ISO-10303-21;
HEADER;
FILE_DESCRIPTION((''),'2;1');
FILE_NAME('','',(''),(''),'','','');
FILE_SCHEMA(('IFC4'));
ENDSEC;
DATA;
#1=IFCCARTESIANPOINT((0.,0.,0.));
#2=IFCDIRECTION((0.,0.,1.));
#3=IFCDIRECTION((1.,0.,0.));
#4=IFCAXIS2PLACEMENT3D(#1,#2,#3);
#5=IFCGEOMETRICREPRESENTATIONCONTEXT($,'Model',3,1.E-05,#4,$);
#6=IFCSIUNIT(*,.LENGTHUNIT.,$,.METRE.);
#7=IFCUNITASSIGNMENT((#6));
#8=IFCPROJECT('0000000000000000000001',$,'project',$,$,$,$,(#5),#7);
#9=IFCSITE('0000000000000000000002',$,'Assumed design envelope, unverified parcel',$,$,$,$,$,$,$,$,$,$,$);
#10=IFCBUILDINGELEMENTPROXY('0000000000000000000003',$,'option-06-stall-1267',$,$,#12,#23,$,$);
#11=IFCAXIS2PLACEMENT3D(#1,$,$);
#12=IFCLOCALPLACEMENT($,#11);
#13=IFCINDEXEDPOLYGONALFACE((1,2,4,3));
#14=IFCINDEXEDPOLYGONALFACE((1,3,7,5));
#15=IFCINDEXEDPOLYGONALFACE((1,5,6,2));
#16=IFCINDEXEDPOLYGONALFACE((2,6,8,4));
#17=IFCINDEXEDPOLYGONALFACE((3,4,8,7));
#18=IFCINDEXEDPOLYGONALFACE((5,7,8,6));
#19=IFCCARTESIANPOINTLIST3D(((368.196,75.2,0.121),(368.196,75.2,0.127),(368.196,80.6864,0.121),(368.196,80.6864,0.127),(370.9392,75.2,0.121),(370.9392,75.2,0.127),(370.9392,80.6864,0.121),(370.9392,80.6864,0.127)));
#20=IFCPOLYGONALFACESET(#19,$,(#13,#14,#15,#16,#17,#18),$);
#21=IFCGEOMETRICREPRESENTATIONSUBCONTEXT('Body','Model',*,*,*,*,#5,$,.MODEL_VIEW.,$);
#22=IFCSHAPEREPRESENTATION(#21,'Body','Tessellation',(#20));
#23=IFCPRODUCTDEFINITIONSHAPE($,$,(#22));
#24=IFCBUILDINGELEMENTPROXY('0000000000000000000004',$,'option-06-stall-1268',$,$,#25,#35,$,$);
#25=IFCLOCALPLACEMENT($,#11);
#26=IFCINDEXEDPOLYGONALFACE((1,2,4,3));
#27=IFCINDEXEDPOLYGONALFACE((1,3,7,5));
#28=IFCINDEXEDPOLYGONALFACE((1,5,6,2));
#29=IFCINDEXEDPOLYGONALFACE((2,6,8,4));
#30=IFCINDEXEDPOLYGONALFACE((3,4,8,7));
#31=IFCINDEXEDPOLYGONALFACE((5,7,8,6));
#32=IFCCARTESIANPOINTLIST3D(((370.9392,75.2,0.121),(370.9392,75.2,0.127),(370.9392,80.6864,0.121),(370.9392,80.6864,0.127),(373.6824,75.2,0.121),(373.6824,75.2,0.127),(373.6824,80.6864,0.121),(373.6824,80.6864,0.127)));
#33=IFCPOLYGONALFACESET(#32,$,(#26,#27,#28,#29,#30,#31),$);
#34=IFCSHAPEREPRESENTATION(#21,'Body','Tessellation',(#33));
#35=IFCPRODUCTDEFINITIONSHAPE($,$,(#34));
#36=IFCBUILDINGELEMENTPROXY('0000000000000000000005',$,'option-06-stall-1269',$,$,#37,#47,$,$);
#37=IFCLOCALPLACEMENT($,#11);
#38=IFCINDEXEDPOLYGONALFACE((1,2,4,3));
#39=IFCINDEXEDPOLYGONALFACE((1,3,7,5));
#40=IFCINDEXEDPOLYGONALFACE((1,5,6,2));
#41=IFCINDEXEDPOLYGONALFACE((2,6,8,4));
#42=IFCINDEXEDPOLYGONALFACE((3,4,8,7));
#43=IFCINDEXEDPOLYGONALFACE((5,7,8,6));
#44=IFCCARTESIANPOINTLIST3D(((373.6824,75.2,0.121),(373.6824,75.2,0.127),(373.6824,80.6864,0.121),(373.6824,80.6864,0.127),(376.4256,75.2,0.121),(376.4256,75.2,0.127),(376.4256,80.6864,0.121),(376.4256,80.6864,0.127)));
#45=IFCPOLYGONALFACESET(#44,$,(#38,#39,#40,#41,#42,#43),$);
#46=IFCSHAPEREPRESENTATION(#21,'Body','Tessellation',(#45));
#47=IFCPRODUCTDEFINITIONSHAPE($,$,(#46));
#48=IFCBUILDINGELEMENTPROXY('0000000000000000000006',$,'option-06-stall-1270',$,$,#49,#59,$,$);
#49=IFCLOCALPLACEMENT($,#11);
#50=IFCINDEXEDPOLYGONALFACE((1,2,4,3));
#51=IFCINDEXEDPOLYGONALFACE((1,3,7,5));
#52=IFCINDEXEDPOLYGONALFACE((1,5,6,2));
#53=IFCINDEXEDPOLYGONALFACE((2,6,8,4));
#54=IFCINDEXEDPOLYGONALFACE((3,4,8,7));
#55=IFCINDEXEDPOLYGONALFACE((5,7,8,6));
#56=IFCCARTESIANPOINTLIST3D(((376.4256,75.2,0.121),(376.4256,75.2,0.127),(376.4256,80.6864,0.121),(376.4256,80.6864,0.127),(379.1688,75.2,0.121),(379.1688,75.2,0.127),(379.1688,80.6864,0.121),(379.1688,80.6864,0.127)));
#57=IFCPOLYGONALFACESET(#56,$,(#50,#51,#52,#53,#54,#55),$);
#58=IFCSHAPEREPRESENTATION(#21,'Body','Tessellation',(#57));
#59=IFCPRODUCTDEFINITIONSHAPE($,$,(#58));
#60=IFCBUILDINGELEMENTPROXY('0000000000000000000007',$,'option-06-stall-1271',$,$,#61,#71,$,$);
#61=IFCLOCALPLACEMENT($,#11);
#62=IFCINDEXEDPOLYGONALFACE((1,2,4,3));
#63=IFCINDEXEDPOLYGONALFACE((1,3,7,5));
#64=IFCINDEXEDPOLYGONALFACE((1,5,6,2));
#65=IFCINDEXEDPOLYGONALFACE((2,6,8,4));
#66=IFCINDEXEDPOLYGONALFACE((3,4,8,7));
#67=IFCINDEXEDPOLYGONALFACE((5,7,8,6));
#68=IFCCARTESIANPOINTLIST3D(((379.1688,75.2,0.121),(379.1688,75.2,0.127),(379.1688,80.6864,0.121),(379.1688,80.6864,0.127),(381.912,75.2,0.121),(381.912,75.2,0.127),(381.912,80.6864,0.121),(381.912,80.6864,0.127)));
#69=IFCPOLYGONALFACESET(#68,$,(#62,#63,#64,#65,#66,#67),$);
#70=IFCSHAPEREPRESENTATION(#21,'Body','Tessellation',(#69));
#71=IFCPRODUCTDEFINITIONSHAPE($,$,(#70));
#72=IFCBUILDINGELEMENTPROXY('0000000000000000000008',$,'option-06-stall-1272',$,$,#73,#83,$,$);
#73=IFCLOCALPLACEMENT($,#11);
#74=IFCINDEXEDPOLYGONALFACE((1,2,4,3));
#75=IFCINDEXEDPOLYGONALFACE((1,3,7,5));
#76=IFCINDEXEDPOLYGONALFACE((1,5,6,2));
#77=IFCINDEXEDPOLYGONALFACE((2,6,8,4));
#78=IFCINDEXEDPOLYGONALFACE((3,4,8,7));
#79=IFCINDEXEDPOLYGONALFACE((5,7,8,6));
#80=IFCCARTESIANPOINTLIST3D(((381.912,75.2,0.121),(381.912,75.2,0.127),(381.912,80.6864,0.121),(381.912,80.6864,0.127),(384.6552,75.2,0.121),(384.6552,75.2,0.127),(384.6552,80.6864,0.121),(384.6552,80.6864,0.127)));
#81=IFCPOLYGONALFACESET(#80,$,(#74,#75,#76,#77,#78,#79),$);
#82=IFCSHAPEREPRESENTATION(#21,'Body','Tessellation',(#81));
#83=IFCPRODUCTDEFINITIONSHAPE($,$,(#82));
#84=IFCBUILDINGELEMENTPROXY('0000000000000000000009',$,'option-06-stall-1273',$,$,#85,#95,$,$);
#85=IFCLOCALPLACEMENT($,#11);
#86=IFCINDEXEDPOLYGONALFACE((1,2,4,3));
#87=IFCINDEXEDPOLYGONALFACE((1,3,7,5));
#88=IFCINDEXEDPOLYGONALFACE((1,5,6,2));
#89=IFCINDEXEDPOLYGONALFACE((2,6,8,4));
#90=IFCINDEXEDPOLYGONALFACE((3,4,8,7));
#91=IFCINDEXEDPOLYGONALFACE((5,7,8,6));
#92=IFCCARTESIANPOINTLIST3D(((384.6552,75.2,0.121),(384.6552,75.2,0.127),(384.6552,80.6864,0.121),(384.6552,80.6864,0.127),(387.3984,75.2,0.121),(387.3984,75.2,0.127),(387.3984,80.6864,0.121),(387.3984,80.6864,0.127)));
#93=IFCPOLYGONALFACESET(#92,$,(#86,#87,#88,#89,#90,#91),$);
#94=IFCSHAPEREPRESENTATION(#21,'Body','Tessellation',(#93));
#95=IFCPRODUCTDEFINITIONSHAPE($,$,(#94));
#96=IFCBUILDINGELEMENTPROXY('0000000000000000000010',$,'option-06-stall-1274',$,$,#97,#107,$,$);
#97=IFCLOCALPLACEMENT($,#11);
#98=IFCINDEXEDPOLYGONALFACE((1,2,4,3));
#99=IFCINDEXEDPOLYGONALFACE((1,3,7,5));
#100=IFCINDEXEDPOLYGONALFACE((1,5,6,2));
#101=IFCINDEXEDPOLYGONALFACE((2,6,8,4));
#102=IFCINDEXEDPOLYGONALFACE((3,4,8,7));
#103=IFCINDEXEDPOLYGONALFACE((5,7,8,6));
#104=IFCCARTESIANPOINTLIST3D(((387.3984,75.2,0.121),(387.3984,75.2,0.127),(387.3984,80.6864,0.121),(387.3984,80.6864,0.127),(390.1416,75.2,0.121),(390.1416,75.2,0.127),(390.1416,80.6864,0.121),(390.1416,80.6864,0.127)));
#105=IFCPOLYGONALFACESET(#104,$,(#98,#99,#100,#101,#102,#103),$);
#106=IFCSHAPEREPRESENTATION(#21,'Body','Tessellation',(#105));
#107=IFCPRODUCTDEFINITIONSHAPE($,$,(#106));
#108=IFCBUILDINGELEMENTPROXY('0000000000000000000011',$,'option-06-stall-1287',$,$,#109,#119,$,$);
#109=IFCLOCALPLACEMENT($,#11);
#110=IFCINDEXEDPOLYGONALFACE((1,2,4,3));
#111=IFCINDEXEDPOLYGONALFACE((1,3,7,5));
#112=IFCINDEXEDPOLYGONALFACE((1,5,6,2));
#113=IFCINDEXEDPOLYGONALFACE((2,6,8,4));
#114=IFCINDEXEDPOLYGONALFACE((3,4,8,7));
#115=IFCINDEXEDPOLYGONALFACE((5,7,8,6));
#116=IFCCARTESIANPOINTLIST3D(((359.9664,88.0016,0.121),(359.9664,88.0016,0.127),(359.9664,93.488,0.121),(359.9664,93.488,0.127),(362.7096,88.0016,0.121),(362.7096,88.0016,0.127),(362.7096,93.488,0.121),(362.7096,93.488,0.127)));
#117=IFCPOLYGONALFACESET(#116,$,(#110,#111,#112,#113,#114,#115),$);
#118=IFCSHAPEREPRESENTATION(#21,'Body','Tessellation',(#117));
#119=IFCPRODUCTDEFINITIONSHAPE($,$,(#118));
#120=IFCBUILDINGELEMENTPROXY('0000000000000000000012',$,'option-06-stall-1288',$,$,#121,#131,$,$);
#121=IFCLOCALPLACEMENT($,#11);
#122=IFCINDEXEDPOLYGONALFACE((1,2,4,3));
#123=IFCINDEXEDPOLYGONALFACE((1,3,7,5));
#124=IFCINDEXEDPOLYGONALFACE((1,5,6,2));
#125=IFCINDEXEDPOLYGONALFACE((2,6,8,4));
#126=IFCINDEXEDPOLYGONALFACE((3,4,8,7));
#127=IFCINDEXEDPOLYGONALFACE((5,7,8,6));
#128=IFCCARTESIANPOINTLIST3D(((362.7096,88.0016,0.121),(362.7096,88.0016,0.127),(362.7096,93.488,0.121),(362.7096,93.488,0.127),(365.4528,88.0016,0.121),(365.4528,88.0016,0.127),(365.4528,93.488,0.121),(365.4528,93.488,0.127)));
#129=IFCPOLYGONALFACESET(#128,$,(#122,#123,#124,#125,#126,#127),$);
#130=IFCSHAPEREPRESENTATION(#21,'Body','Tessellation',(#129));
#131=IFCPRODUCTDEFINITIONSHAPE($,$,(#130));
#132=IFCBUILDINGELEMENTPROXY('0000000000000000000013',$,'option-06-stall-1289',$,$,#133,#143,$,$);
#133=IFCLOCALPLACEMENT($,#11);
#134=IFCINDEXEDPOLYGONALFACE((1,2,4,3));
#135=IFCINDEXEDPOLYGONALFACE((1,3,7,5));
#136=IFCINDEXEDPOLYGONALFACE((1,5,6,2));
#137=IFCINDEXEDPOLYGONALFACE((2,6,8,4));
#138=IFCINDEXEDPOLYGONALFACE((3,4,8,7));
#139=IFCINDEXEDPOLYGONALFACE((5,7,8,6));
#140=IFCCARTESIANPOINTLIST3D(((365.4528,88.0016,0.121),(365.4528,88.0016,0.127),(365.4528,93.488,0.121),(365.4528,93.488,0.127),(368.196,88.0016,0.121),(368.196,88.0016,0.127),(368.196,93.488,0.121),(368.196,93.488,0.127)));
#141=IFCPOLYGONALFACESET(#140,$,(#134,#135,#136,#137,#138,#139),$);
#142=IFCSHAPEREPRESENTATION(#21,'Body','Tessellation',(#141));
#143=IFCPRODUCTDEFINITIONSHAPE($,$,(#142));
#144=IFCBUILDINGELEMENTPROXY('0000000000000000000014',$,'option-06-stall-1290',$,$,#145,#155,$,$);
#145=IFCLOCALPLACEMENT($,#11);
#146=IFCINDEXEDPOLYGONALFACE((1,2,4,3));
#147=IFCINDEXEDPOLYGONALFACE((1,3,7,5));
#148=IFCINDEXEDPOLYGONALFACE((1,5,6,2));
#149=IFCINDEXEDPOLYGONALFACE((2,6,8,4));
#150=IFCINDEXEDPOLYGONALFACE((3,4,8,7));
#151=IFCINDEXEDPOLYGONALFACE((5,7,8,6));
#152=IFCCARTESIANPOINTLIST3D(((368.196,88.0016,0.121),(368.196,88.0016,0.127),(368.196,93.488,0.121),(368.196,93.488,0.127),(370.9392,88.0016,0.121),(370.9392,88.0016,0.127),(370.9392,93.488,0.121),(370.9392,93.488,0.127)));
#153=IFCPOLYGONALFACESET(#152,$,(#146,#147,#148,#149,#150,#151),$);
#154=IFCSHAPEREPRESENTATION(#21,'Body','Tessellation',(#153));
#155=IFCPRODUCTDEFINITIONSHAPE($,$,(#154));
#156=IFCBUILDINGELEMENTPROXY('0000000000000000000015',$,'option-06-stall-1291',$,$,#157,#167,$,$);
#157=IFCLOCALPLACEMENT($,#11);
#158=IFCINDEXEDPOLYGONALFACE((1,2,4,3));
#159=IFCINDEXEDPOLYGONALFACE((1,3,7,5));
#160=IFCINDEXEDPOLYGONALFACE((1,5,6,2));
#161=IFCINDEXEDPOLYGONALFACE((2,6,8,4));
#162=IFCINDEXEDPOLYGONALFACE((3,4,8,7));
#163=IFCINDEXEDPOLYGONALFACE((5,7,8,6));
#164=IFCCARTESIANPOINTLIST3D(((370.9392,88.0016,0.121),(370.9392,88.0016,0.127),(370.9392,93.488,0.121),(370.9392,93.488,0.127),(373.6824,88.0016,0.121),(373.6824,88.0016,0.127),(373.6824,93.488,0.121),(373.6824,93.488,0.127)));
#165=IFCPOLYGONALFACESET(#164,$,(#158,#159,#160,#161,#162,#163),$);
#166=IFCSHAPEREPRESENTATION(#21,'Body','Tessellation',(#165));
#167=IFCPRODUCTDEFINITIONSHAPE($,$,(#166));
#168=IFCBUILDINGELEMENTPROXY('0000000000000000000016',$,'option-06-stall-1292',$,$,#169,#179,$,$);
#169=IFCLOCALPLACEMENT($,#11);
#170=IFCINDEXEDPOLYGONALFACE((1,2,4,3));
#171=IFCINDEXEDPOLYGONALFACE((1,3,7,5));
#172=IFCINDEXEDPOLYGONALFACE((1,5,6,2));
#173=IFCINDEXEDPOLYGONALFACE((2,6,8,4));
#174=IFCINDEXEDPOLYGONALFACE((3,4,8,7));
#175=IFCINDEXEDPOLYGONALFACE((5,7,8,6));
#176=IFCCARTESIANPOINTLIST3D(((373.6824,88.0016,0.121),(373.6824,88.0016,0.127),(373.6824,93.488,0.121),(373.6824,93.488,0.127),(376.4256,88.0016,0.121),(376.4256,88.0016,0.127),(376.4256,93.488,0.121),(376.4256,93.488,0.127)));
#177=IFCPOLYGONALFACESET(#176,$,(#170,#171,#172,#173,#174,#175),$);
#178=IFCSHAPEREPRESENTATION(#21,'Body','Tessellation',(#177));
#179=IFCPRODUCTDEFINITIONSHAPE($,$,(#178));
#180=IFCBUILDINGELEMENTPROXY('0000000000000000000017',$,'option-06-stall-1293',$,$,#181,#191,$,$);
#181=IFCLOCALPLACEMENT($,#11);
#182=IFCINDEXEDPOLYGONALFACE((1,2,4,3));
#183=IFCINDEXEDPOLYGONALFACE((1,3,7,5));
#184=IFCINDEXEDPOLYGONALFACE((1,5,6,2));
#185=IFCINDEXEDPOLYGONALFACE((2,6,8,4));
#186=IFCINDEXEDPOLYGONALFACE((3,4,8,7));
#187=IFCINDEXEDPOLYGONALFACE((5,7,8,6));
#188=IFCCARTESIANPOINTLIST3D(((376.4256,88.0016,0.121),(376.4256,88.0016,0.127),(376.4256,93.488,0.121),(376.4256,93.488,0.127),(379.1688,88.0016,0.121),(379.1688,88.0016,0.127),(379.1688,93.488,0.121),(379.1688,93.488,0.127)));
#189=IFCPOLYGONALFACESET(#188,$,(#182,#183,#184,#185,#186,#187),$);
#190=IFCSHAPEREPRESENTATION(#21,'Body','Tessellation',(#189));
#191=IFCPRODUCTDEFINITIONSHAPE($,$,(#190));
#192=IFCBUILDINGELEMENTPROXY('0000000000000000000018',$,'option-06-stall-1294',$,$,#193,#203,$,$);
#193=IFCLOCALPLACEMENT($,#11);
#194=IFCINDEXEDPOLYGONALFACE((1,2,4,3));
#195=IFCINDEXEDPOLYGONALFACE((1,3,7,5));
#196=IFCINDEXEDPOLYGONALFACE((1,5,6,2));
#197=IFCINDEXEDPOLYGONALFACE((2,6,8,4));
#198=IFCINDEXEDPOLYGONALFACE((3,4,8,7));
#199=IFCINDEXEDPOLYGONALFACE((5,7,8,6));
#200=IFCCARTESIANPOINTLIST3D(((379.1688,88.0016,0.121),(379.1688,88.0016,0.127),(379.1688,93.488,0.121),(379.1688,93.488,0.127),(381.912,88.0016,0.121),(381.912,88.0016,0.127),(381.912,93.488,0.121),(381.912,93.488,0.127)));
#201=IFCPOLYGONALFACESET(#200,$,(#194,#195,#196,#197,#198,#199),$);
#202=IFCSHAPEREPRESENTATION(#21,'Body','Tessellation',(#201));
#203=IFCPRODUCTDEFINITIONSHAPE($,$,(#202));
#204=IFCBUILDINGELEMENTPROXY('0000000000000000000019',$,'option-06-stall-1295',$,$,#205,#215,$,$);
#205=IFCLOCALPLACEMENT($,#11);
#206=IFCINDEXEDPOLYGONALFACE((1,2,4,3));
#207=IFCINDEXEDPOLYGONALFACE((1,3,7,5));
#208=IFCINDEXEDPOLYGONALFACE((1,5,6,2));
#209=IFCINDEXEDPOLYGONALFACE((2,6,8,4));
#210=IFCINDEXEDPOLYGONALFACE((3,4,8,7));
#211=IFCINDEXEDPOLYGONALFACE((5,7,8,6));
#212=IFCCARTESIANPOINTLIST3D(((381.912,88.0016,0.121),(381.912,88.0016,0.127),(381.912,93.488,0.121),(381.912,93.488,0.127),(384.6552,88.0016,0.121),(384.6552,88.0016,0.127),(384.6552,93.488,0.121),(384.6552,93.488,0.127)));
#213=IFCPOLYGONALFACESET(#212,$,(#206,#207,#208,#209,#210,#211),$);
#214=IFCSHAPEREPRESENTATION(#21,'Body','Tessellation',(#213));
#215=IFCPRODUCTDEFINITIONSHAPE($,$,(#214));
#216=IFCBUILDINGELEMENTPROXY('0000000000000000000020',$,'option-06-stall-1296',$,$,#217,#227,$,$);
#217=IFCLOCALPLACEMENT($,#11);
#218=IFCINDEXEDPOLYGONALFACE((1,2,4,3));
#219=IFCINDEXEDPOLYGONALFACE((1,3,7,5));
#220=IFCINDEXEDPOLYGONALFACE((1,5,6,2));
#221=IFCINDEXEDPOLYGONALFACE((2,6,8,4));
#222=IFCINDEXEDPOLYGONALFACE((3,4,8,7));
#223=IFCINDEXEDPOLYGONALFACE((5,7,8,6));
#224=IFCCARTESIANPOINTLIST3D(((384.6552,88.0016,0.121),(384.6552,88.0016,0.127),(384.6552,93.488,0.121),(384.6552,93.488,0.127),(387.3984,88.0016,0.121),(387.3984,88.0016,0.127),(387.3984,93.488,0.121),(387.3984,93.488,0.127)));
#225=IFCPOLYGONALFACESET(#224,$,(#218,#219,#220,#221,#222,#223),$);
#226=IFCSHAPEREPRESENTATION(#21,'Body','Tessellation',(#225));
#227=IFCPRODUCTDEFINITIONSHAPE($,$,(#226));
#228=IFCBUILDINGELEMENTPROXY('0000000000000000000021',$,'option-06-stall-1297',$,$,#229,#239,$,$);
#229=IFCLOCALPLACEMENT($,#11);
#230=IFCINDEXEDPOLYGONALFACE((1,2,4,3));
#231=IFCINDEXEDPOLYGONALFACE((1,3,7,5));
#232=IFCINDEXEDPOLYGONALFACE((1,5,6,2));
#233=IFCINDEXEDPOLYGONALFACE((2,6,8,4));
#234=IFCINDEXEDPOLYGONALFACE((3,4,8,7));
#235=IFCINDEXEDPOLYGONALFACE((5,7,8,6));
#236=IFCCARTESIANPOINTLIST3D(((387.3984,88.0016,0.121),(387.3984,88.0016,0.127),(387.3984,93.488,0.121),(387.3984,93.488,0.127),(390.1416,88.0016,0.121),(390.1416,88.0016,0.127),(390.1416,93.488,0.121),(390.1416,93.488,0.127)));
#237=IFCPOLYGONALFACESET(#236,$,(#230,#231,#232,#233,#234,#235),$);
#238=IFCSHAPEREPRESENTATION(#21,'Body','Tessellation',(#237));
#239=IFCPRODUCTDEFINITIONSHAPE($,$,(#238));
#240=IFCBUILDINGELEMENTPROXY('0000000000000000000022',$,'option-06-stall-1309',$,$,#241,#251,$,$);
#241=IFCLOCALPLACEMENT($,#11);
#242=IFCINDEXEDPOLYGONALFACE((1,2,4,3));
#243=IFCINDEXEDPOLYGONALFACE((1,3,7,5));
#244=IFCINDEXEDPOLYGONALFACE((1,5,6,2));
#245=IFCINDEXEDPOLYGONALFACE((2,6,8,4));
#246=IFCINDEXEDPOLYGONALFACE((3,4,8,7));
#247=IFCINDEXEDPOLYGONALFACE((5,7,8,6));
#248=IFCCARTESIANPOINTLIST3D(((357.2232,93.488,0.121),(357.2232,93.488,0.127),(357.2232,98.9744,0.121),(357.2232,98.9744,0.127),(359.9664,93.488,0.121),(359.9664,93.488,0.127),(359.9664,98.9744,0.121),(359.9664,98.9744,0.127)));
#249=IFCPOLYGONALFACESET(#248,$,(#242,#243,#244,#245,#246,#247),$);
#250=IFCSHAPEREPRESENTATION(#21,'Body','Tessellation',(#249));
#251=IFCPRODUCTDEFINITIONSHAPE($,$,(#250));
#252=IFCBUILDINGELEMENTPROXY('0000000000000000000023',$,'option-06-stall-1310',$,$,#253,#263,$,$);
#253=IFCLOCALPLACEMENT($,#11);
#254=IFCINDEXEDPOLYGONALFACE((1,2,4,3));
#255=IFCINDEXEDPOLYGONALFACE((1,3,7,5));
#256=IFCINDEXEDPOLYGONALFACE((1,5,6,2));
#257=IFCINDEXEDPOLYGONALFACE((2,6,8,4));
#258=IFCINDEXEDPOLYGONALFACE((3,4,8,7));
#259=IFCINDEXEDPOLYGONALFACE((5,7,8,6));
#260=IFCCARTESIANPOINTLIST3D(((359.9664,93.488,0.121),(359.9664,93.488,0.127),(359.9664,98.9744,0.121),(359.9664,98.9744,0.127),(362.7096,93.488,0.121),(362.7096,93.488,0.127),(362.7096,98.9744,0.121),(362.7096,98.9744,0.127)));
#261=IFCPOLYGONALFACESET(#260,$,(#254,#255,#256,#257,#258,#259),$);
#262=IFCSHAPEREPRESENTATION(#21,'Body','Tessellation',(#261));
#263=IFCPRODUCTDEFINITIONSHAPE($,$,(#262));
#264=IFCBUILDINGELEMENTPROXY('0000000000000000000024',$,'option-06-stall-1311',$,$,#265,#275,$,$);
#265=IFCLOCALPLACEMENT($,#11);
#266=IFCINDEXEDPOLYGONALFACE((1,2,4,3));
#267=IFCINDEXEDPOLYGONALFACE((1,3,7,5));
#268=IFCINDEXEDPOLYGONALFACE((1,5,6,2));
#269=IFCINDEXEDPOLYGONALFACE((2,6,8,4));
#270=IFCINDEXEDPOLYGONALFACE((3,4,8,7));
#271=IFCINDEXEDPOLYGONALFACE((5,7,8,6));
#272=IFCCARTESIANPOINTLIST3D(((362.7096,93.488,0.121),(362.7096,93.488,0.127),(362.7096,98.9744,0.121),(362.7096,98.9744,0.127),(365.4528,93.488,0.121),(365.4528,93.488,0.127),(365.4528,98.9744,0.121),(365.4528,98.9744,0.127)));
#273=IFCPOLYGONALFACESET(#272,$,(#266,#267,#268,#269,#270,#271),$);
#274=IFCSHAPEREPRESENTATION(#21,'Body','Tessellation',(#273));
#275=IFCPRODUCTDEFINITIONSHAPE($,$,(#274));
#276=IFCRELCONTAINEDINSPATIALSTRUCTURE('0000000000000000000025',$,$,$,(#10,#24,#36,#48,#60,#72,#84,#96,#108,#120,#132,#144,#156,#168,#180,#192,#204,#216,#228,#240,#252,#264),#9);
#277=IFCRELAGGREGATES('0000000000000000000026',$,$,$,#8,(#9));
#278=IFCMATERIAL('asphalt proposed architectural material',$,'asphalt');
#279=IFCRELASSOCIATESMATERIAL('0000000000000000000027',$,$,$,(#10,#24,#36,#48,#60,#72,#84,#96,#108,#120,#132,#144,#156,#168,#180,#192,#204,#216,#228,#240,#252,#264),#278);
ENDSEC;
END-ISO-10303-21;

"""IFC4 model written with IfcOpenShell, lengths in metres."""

from ifc_helpers import new_model, si_unit, frame, origin_with_axes, place, context, subcontext, project, spatial, rectangle, extrude, material, element, save


model = new_model("IFC4")

# Units and contexts
model_context = context("Model", 3, precision=1e-05, world=origin_with_axes())
body_context = subcontext(model_context, "Body", "Model", "MODEL_VIEW")
ifc_project = project(units=[si_unit("LENGTHUNIT", "METRE")], contexts=[model_context])

# Site
site = spatial("IfcSite", under=ifc_project, Name="Assumed design envelope, unverified parcel")

# Building element proxies
ifc_material = material(Name="asphalt proposed architectural material", Category="asphalt")
for number, where, z_axis, x_axis, name in (
    (1, (369.5676, 77.9432, 0.121), (0.0, 0.0, 1.0), (1.0, 0.0, 0.0), "option-06-stall-1267"),
    (2, (372.3108, 77.9432, 0.121), (0.0, 0.0, 1.0), (1.0, 0.0, 0.0), "option-06-stall-1268"),
    (3, (375.054, 77.9432, 0.121), (0.0, 0.0, 1.0), (1.0, 0.0, 0.0), "option-06-stall-1269"),
    (4, (377.7972, 77.9432, 0.121), (0.0, 0.0, 1.0), (1.0, 0.0, 0.0), "option-06-stall-1270"),
    (5, (380.5404, 77.9432, 0.121), (0.0, 0.0, 1.0), (1.0, 0.0, 0.0), "option-06-stall-1271"),
    (6, (383.2836, 77.9432, 0.121), (0.0, 0.0, 1.0), (1.0, 0.0, 0.0), "option-06-stall-1272"),
    (7, (386.0268, 77.9432, 0.121), (0.0, 0.0, 1.0), (1.0, 0.0, 0.0), "option-06-stall-1273"),
    (8, (388.77, 77.9432, 0.121), (0.0, 0.0, 1.0), (1.0, 0.0, 0.0), "option-06-stall-1274"),
    (9, (361.338, 90.7448, 0.121), (0.0, 0.0, 1.0), (1.0, 0.0, 0.0), "option-06-stall-1287"),
    (10, (364.0812, 90.7448, 0.121), (0.0, 0.0, 1.0), (1.0, 0.0, 0.0), "option-06-stall-1288"),
    (11, (366.8244, 90.7448, 0.121), (0.0, 0.0, 1.0), (1.0, 0.0, 0.0), "option-06-stall-1289"),
    (12, (369.5676, 90.7448, 0.121), (0.0, 0.0, 1.0), (1.0, 0.0, 0.0), "option-06-stall-1290"),
    (13, (372.3108, 90.7448, 0.121), (0.0, 0.0, 1.0), (1.0, 0.0, 0.0), "option-06-stall-1291"),
    (14, (375.054, 90.7448, 0.121), (0.0, 0.0, 1.0), (1.0, 0.0, 0.0), "option-06-stall-1292"),
    (15, (377.7972, 90.7448, 0.121), (0.0, 0.0, 1.0), (1.0, 0.0, 0.0), "option-06-stall-1293"),
    (16, (380.5404, 90.7448, 0.121), (0.0, 0.0, 1.0), (1.0, 0.0, 0.0), "option-06-stall-1294"),
    (17, (383.2836, 90.7448, 0.121), (0.0, 0.0, 1.0), (1.0, 0.0, 0.0), "option-06-stall-1295"),
    (18, (386.0268, 90.7448, 0.121), (0.0, 0.0, 1.0), (1.0, 0.0, 0.0), "option-06-stall-1296"),
    (19, (388.77, 90.7448, 0.121), (0.0, 0.0, 1.0), (1.0, 0.0, 0.0), "option-06-stall-1297"),
    (20, (358.5948, 96.2312, 0.121), (0.0, 0.0, 1.0), (1.0, 0.0, 0.0), "option-06-stall-1309"),
    (21, (361.338, 96.2312, 0.121), (0.0, 0.0, 1.0), (1.0, 0.0, 0.0), "option-06-stall-1310"),
    (22, (364.0812, 96.2312, 0.121), (0.0, 0.0, 1.0), (1.0, 0.0, 0.0), "option-06-stall-1311"),
):
    element("IfcBuildingElementProxy", number, at=place(None, frame(where, z_axis=z_axis, x_axis=x_axis)), inside=site, material=ifc_material, Name=name, context=body_context, shape_type="SweptSolid", body=[
        extrude(rectangle(XDim=2.7432, YDim=5.4864), origin_with_axes(), (0.0, 0.0, 1.0), 0.006),
    ])

save(model, "model.ifc")
